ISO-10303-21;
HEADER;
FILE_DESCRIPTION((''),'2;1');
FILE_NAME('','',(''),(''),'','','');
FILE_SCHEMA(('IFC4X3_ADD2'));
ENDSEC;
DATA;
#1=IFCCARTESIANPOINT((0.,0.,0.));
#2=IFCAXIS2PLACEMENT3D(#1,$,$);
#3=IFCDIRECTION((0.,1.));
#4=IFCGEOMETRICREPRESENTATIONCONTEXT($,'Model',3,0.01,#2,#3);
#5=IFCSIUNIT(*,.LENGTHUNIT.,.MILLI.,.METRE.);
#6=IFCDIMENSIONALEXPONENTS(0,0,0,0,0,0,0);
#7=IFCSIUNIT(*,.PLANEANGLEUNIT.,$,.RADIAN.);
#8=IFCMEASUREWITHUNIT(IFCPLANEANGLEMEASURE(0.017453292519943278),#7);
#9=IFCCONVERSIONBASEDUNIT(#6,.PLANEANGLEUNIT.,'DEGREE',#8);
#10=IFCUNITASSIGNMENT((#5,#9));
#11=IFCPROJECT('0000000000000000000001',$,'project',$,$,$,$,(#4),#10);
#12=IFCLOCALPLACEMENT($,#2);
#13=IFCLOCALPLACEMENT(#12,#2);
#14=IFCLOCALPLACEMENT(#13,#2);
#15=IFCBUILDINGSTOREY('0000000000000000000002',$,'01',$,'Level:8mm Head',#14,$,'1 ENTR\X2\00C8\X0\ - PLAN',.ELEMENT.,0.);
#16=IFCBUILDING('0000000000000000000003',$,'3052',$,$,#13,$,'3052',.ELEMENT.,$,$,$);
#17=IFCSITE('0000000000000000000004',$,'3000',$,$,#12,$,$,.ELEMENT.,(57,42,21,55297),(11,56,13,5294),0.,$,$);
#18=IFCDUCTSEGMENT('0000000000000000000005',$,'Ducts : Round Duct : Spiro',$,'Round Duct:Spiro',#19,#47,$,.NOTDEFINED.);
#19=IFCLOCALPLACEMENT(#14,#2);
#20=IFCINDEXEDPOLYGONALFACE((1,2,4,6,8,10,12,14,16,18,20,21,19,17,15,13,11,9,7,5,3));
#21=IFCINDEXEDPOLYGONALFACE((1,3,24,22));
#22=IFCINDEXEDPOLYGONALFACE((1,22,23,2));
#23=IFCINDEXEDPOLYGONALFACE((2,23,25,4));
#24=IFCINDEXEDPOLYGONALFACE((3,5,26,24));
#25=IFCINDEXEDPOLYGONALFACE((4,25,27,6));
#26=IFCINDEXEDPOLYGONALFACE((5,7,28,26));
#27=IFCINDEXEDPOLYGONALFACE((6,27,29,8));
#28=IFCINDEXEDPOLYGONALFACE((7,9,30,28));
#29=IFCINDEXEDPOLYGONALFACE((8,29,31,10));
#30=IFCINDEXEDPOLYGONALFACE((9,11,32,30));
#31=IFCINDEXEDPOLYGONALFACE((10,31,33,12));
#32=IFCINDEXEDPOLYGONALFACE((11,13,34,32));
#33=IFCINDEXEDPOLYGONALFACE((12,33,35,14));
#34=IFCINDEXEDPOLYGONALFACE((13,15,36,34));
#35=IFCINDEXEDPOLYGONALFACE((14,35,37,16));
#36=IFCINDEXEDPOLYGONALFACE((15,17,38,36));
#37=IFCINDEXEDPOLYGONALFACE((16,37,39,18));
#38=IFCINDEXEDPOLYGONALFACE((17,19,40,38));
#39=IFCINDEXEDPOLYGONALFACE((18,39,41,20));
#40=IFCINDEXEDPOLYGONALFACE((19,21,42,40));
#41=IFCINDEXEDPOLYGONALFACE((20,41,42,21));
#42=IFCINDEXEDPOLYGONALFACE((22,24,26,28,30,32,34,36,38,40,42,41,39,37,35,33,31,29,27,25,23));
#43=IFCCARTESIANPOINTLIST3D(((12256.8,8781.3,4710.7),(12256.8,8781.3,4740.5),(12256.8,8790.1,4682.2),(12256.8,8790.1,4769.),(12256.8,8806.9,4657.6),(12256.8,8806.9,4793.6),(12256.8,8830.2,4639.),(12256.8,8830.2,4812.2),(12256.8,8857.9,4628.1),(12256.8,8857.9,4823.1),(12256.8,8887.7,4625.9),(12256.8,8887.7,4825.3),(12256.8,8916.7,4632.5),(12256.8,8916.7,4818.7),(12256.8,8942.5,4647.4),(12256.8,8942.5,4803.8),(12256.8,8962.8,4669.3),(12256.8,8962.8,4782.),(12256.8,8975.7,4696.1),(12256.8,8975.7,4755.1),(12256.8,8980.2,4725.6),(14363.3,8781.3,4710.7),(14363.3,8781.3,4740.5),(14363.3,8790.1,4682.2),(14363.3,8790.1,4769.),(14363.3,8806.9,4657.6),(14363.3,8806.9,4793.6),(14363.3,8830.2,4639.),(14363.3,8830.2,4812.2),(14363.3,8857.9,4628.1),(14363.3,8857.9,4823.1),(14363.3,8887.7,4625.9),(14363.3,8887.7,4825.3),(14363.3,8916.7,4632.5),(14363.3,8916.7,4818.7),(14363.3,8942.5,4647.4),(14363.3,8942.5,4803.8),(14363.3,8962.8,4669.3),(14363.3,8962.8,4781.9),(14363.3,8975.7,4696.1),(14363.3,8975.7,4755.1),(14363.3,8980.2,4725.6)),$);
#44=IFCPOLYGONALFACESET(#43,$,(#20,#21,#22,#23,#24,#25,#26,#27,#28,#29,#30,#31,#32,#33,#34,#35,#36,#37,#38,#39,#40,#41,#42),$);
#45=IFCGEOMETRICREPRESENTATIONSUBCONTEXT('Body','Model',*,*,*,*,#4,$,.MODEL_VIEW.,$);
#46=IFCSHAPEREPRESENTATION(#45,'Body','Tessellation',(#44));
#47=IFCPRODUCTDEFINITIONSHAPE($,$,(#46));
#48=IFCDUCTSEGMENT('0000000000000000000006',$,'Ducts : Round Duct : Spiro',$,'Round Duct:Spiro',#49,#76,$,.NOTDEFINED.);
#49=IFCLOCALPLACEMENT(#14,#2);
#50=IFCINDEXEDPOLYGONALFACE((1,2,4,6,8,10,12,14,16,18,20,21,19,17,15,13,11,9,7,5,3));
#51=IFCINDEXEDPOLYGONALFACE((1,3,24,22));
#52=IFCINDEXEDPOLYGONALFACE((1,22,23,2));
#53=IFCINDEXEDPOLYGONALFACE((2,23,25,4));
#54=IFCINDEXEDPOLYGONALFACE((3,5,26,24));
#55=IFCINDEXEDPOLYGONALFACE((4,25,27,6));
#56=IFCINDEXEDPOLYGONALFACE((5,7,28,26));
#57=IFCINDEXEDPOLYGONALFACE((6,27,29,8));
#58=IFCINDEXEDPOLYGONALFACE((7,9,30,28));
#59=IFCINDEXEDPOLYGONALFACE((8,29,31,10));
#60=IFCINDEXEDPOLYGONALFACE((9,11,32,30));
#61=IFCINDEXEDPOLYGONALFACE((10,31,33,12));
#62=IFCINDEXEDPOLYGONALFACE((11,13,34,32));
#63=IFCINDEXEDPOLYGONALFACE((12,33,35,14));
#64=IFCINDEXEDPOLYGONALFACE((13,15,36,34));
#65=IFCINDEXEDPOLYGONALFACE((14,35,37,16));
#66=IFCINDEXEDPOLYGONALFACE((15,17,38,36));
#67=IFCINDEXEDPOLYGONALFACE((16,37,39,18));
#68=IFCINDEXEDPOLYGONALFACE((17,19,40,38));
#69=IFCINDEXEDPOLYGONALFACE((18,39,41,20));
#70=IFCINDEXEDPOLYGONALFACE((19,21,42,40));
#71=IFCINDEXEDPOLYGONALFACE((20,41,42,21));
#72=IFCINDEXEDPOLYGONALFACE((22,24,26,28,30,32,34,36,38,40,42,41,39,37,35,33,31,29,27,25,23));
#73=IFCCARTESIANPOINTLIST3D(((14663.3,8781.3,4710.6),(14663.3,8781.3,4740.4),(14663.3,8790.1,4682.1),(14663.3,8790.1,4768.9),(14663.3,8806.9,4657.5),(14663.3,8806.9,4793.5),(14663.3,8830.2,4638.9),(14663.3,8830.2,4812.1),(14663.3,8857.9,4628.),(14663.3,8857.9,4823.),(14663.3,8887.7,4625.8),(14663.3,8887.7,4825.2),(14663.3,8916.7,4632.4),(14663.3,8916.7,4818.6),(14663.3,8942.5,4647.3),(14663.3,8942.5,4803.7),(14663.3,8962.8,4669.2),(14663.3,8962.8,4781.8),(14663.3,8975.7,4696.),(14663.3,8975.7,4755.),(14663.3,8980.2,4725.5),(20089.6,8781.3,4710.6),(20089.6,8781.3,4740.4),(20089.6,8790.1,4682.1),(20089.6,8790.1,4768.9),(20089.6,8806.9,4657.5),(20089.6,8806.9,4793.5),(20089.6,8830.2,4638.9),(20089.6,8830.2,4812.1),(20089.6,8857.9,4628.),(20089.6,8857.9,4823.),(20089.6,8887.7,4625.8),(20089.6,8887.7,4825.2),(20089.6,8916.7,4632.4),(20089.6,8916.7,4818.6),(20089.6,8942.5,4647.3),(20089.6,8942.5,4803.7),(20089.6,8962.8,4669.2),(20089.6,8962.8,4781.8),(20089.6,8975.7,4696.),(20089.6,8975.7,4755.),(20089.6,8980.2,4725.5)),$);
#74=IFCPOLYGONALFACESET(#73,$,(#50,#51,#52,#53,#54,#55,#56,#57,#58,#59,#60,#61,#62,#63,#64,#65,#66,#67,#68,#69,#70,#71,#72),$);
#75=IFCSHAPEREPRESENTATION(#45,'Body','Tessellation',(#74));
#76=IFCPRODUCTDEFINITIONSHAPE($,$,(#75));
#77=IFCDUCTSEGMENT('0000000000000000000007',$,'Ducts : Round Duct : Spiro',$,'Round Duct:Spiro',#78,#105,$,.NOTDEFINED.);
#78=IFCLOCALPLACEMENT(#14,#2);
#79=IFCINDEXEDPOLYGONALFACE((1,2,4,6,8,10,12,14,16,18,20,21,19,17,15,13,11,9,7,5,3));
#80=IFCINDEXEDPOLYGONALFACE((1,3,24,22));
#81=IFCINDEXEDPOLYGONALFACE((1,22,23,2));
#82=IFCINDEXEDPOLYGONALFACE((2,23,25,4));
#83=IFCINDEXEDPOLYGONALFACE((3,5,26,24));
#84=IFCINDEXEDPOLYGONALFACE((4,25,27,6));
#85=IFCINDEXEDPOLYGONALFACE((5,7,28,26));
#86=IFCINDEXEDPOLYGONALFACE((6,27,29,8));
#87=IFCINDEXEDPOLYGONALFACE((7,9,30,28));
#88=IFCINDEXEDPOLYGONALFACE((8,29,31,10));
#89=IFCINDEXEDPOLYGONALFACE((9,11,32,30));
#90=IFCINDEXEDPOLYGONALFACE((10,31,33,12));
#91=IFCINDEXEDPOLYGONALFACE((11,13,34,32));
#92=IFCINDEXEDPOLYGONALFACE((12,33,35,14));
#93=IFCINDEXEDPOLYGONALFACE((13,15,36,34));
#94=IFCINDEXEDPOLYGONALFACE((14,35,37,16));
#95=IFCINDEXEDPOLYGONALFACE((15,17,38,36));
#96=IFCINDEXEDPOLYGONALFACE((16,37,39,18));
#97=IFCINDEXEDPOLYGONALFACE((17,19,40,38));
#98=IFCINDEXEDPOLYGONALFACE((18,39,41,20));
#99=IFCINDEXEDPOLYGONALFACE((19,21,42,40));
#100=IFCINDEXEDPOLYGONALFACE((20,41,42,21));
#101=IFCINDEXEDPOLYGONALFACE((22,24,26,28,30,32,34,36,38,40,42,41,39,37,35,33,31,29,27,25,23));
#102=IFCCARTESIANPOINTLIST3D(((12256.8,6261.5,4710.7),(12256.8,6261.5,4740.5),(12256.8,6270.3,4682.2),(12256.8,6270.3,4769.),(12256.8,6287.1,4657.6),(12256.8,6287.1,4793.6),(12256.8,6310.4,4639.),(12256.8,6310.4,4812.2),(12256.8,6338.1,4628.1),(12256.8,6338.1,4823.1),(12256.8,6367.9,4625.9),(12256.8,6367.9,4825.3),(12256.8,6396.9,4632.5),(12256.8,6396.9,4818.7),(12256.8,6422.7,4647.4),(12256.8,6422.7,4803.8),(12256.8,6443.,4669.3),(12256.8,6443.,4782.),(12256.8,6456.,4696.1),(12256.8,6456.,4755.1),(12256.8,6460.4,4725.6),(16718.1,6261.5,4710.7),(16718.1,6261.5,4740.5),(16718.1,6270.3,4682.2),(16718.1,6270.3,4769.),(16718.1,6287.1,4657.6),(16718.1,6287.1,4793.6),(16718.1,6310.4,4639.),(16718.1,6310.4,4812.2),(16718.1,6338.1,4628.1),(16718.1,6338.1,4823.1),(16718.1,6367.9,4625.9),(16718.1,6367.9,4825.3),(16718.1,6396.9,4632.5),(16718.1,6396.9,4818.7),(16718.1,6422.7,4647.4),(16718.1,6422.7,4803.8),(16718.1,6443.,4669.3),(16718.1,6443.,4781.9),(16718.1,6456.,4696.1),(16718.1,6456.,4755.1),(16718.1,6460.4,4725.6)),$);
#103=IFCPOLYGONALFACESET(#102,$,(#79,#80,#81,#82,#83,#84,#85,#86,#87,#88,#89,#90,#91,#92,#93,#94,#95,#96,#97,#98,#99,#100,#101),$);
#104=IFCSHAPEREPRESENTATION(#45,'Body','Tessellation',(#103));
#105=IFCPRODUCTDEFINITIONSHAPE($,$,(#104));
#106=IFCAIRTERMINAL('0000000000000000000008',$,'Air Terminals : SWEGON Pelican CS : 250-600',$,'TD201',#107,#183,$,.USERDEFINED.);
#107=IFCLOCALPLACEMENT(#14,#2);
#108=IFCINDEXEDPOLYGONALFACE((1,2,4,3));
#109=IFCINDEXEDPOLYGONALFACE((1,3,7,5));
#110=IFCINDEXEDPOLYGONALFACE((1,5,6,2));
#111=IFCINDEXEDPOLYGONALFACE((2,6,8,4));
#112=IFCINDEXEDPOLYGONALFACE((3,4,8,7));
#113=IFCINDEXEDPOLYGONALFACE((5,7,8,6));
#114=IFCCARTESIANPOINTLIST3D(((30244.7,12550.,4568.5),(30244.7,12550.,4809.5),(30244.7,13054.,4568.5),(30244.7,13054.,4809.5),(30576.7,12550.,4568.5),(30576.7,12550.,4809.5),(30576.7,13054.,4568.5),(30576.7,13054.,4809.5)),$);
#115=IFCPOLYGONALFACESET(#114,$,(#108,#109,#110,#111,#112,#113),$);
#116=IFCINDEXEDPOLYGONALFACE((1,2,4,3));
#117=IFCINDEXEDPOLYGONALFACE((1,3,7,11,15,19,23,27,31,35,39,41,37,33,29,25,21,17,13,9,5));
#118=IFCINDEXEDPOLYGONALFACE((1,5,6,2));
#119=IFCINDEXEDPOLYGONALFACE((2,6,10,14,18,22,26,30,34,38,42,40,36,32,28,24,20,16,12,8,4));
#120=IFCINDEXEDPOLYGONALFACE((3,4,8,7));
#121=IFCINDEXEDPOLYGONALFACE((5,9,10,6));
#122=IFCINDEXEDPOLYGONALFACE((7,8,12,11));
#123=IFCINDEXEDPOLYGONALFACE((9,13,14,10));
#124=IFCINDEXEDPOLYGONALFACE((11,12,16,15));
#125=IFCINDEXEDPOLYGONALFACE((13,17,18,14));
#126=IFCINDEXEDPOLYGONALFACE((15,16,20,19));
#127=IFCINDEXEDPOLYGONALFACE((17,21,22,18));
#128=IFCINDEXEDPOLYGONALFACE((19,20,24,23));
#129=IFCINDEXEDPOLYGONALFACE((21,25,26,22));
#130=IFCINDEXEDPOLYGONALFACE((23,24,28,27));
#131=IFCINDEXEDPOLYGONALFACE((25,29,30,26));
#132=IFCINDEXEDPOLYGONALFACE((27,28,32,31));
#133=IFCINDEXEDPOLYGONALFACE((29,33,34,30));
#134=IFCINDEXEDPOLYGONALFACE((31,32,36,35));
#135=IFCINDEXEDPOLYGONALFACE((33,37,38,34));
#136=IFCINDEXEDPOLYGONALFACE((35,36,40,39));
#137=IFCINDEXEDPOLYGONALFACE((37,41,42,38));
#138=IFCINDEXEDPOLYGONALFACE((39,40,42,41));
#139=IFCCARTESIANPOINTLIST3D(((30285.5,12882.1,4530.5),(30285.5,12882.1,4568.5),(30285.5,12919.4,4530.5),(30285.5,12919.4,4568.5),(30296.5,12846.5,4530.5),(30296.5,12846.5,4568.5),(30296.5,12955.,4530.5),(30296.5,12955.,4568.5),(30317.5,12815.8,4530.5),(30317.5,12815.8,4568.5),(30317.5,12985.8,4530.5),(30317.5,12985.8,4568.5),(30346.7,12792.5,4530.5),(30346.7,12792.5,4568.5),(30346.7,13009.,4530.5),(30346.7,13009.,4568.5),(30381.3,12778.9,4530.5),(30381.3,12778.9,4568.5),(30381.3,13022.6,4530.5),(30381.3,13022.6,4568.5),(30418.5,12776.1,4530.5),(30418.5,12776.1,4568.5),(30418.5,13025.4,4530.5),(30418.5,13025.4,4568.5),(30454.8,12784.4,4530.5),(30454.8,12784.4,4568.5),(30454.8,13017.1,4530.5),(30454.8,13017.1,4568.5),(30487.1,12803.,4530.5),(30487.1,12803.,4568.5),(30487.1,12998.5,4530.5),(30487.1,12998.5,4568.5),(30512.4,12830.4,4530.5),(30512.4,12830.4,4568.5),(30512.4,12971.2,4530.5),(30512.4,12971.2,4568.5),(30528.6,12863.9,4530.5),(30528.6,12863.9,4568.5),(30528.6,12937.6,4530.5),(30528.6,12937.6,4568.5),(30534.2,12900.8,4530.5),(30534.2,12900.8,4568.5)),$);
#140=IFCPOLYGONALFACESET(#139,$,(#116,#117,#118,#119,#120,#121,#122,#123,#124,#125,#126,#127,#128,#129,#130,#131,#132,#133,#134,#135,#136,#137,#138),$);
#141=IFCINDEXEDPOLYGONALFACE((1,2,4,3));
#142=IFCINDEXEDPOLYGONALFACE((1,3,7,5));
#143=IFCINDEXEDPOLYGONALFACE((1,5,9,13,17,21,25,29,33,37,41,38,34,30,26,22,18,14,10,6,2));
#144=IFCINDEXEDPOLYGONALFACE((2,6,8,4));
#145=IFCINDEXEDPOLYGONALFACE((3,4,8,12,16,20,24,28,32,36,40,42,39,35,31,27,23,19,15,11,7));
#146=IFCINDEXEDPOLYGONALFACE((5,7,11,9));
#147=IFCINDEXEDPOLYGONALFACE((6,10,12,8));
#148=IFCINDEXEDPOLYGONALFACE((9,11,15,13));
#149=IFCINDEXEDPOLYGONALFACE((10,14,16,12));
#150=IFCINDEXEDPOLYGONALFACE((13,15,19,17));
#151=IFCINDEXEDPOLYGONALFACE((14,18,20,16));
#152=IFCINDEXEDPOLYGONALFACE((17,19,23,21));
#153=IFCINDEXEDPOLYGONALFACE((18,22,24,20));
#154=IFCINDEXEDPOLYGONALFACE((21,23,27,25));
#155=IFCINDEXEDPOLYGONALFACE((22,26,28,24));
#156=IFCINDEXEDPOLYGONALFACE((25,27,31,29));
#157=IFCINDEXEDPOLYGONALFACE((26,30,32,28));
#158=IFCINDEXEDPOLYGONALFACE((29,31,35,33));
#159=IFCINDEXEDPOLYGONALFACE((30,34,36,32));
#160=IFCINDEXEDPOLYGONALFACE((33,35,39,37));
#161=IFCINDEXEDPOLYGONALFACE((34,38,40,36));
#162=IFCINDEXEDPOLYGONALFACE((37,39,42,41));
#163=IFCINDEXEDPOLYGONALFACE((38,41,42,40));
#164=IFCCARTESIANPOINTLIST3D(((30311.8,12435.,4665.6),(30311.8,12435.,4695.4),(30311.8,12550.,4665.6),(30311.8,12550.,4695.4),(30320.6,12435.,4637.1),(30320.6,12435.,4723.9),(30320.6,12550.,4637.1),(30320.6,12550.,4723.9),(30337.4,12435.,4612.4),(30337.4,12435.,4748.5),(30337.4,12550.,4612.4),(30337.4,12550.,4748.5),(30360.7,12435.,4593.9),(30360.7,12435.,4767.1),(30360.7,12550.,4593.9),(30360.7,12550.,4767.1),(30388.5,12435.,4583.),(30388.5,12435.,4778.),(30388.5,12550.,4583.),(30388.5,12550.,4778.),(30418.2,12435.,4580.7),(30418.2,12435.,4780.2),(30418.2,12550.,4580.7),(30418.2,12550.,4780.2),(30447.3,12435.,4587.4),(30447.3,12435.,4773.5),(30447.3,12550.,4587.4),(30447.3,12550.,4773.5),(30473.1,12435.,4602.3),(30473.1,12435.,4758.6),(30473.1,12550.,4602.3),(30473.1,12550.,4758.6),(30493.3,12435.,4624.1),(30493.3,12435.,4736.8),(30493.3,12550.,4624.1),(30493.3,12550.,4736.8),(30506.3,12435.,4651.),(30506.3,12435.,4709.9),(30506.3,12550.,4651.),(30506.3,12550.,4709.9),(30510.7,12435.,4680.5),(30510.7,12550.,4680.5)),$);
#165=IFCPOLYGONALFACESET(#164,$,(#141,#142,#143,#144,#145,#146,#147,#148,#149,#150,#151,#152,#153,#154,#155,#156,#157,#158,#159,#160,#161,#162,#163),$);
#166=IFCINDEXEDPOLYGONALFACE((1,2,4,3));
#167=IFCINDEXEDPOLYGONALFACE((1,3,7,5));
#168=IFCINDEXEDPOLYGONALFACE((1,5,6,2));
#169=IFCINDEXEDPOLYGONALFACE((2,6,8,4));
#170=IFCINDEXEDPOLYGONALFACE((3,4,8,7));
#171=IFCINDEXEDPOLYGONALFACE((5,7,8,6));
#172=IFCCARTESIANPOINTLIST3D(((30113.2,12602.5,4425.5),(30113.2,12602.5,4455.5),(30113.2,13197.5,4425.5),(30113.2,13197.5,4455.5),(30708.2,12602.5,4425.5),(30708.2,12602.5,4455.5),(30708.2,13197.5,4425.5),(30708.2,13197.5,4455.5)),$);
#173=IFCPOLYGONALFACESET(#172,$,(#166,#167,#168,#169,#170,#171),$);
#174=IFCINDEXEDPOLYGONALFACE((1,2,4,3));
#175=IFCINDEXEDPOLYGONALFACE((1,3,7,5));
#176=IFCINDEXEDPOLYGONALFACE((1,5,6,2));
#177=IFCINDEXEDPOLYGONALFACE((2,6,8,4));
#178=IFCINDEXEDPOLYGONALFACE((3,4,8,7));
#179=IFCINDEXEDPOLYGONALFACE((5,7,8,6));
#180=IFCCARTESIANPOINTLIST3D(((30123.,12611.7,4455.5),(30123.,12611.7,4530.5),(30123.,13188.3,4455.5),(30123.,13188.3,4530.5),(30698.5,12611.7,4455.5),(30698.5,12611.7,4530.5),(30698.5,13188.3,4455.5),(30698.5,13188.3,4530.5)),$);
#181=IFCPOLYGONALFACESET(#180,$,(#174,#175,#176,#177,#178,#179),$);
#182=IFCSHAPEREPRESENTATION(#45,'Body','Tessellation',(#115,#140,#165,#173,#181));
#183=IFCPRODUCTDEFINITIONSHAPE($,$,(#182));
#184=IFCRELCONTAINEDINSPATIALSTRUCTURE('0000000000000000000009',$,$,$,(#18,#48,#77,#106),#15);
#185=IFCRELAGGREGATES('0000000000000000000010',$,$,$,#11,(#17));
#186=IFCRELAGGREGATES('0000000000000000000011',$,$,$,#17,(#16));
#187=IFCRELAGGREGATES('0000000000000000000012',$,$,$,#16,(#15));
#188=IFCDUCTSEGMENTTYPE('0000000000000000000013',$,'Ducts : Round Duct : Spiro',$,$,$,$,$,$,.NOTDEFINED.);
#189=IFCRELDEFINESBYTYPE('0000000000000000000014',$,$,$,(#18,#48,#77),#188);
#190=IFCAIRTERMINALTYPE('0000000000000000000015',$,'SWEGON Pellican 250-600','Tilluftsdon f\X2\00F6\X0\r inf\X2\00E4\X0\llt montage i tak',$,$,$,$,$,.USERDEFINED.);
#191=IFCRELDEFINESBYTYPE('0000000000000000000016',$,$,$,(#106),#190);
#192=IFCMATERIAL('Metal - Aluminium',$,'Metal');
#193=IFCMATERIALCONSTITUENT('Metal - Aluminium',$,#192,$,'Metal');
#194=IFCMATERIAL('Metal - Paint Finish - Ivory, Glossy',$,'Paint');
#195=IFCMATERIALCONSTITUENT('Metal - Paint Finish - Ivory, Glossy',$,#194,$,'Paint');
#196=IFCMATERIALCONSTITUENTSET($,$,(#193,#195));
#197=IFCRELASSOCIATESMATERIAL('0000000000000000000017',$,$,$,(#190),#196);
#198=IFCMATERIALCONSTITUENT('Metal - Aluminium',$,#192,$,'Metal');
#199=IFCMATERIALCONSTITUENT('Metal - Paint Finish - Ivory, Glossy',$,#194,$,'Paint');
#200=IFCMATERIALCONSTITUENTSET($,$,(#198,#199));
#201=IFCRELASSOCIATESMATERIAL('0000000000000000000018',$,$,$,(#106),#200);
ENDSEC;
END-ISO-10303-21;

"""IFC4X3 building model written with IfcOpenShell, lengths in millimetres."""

from ifc_helpers import new_model, entity, si_unit, converted_unit, direction, frame, frame_2d, origin, origin_2d_with_axis, place, context, subcontext, project, spatial, rectangle, circle, extrude, source, transform, mapped, material, constituent, constituent_set, type_object, type_shapes, element, save


model = new_model("IFC4X3")

# Units and contexts
model_context = context("Model", 3, precision=0.01, world=origin(), true_north=direction((0.0, 1.0)))
body_context = subcontext(model_context, "Body", "Model", "MODEL_VIEW")
ifc_project = project(units=[si_unit("LENGTHUNIT", "METRE", prefix="MILLI"), converted_unit("PLANEANGLEUNIT", "DEGREE", entity("IfcPlaneAngleMeasure", 0.017453292519943278), si_unit("PLANEANGLEUNIT", "RADIAN"), dimensions=[0, 0, 0, 0, 0, 0, 0])], contexts=[model_context])

# Site, building, storey
site_placement = place(None, origin())
site = spatial("IfcSite", under=ifc_project, at=site_placement, Name="3000", CompositionType="ELEMENT", RefLatitude=(57, 42, 21, 55297), RefLongitude=(11, 56, 13, 5294), RefElevation=0.0)
building_placement = place(site_placement, origin())
building = spatial("IfcBuilding", under=site, at=building_placement, Name="3052", LongName="3052", CompositionType="ELEMENT")
storey_placement = place(building_placement, origin())
storey = spatial("IfcBuildingStorey", under=building, at=storey_placement, Name="01", ObjectType="Level:8mm Head", LongName="1 ENTRÈ - PLAN", CompositionType="ELEMENT", Elevation=0.0)

# Duct segments
duct_segment_type = type_object("IfcDuctSegmentType", Name="Ducts : Round Duct : Spiro", PredefinedType="NOTDEFINED")
duct_segment_1_placement = place(storey_placement, frame((12256.8, 8778.6, 4827.2)))
element("IfcDuctSegment", 1, at=duct_segment_1_placement, inside=storey, type_object=duct_segment_type, Name="Ducts : Round Duct : Spiro", ObjectType="Round Duct:Spiro", PredefinedType="NOTDEFINED", context=body_context, shape_type="SweptSolid", body=[
    extrude(circle(Radius=100.0, at=frame_2d((0.0, 0.0), x_axis=(1.0, 0.0))), frame((0.0, 101.6, -101.6), z_axis=(1.0, 0.0, -0.000012), x_axis=(0.0, 1.0, 0.0)), (0.0, 0.0, 1.0), 2106.5),
])
duct_segment_2_placement = place(storey_placement, frame((14663.3, 8778.6, 4827.1)))
element("IfcDuctSegment", 2, at=duct_segment_2_placement, inside=storey, type_object=duct_segment_type, Name="Ducts : Round Duct : Spiro", ObjectType="Round Duct:Spiro", PredefinedType="NOTDEFINED", context=body_context, shape_type="SweptSolid", body=[
    extrude(circle(Radius=100.0, at=frame_2d((0.0, 0.0), x_axis=(1.0, 0.0))), frame((0.0, 101.6, -101.6), z_axis=(1.0, 0.0, -0.000001), x_axis=(0.0, 1.0, 0.0)), (0.0, 0.0, 1.0), 5426.3),
])
duct_segment_3_placement = place(storey_placement, frame((12256.8, 6258.8, 4827.2)))
element("IfcDuctSegment", 3, at=duct_segment_3_placement, inside=storey, type_object=duct_segment_type, Name="Ducts : Round Duct : Spiro", ObjectType="Round Duct:Spiro", PredefinedType="NOTDEFINED", context=body_context, shape_type="SweptSolid", body=[
    extrude(circle(Radius=100.0, at=frame_2d((0.0, 0.0), x_axis=(1.0, 0.0))), frame((0.0, 101.6, -101.6), z_axis=(1.0, 0.0, -0.000004), x_axis=(0.0, 1.0, 0.0)), (0.0, 0.0, 1.0), 4461.3),
])

# Air terminal
ifc_material_1 = material(Name="Metal - Aluminium", Category="Metal")
ifc_constituent_1 = constituent(ifc_material_1, Name="Metal - Aluminium", Category="Metal")
ifc_material_2 = material(Name="Metal - Paint Finish - Ivory, Glossy", Category="Paint")
ifc_constituent_2 = constituent(ifc_material_2, Name="Metal - Paint Finish - Ivory, Glossy", Category="Paint")
ifc_constituent_set_1 = constituent_set(constituents=[ifc_constituent_1, ifc_constituent_2])
ifc_constituent_3 = constituent(ifc_material_1, Name="Metal - Aluminium", Category="Metal")
ifc_constituent_4 = constituent(ifc_material_2, Name="Metal - Paint Finish - Ivory, Glossy", Category="Paint")
ifc_constituent_set_2 = constituent_set(constituents=[ifc_constituent_3, ifc_constituent_4])
air_terminal_type_1 = type_object("IfcAirTerminalType", Name="SWEGON Pellican 250-600", Description="Tilluftsdon för infällt montage i tak", PredefinedType="USERDEFINED", material=ifc_constituent_set_2)
shared_shape_1 = source(origin(), body_context, "Body", "SweptSolid", [
    extrude(rectangle(XDim=332.0, YDim=504.0, at=origin_2d_with_axis()), frame((0.0, 98.0, -354.0), z_axis=(0.0, 0.0, 1.0), x_axis=(-1.0, 0.0, 0.0)), (0.0, 0.0, 1.0), 241.0),
    extrude(circle(Radius=125.0, at=frame_2d((0.0, 0.0), x_axis=(1.0, 0.0))), frame((-1.6, -0.8, -113.0)), (0.0, 0.0, 1.0), 38.0),
    extrude(circle(Radius=100.0, at=frame_2d((0.0, 0.0), x_axis=(1.0, 0.0))), frame((0.0, 350.0, -225.0), z_axis=(0.0, 1.0, 0.0), x_axis=(1.0, 0.0, 0.0)), (0.0, 0.0, 1.0), 115.0),
    extrude(rectangle(XDim=595.0, YDim=595.0, at=frame_2d((0.0, 0.0), x_axis=(1.0, 0.0))), frame((0.0, 0.0, 0.0), z_axis=(0.0, 0.0, 1.0), x_axis=(-1.0, 0.0, 0.0)), (0.0, 0.0, 1.0), 30.0),
    extrude(rectangle(XDim=575.5, YDim=576.5, at=origin_2d_with_axis()), frame((0.0, 0.0, -75.0), z_axis=(0.0, 0.0, 1.0), x_axis=(-1.0, 0.0, 0.0)), (0.0, 0.0, 1.0), 75.0),
])
type_shapes(air_terminal_type_1, [shared_shape_1])
air_terminal_1_placement = place(storey_placement, frame((30410.7, 12900.0, 4455.5), z_axis=(0.0, 0.0, -1.0), x_axis=(1.0, 0.0, 0.0)))
element("IfcAirTerminal", 4, at=air_terminal_1_placement, inside=storey, type_object=air_terminal_type_1, material=ifc_constituent_set_1, Name="Air Terminals : SWEGON Pelican CS : 250-600", ObjectType="TD201", PredefinedType="USERDEFINED", context=body_context, shape_type="MappedRepresentation", body=[
    mapped(shared_shape_1, transform((0.0, 0.0, 0.0), scale=1.0)),
])

save(model, "model.ifc")
